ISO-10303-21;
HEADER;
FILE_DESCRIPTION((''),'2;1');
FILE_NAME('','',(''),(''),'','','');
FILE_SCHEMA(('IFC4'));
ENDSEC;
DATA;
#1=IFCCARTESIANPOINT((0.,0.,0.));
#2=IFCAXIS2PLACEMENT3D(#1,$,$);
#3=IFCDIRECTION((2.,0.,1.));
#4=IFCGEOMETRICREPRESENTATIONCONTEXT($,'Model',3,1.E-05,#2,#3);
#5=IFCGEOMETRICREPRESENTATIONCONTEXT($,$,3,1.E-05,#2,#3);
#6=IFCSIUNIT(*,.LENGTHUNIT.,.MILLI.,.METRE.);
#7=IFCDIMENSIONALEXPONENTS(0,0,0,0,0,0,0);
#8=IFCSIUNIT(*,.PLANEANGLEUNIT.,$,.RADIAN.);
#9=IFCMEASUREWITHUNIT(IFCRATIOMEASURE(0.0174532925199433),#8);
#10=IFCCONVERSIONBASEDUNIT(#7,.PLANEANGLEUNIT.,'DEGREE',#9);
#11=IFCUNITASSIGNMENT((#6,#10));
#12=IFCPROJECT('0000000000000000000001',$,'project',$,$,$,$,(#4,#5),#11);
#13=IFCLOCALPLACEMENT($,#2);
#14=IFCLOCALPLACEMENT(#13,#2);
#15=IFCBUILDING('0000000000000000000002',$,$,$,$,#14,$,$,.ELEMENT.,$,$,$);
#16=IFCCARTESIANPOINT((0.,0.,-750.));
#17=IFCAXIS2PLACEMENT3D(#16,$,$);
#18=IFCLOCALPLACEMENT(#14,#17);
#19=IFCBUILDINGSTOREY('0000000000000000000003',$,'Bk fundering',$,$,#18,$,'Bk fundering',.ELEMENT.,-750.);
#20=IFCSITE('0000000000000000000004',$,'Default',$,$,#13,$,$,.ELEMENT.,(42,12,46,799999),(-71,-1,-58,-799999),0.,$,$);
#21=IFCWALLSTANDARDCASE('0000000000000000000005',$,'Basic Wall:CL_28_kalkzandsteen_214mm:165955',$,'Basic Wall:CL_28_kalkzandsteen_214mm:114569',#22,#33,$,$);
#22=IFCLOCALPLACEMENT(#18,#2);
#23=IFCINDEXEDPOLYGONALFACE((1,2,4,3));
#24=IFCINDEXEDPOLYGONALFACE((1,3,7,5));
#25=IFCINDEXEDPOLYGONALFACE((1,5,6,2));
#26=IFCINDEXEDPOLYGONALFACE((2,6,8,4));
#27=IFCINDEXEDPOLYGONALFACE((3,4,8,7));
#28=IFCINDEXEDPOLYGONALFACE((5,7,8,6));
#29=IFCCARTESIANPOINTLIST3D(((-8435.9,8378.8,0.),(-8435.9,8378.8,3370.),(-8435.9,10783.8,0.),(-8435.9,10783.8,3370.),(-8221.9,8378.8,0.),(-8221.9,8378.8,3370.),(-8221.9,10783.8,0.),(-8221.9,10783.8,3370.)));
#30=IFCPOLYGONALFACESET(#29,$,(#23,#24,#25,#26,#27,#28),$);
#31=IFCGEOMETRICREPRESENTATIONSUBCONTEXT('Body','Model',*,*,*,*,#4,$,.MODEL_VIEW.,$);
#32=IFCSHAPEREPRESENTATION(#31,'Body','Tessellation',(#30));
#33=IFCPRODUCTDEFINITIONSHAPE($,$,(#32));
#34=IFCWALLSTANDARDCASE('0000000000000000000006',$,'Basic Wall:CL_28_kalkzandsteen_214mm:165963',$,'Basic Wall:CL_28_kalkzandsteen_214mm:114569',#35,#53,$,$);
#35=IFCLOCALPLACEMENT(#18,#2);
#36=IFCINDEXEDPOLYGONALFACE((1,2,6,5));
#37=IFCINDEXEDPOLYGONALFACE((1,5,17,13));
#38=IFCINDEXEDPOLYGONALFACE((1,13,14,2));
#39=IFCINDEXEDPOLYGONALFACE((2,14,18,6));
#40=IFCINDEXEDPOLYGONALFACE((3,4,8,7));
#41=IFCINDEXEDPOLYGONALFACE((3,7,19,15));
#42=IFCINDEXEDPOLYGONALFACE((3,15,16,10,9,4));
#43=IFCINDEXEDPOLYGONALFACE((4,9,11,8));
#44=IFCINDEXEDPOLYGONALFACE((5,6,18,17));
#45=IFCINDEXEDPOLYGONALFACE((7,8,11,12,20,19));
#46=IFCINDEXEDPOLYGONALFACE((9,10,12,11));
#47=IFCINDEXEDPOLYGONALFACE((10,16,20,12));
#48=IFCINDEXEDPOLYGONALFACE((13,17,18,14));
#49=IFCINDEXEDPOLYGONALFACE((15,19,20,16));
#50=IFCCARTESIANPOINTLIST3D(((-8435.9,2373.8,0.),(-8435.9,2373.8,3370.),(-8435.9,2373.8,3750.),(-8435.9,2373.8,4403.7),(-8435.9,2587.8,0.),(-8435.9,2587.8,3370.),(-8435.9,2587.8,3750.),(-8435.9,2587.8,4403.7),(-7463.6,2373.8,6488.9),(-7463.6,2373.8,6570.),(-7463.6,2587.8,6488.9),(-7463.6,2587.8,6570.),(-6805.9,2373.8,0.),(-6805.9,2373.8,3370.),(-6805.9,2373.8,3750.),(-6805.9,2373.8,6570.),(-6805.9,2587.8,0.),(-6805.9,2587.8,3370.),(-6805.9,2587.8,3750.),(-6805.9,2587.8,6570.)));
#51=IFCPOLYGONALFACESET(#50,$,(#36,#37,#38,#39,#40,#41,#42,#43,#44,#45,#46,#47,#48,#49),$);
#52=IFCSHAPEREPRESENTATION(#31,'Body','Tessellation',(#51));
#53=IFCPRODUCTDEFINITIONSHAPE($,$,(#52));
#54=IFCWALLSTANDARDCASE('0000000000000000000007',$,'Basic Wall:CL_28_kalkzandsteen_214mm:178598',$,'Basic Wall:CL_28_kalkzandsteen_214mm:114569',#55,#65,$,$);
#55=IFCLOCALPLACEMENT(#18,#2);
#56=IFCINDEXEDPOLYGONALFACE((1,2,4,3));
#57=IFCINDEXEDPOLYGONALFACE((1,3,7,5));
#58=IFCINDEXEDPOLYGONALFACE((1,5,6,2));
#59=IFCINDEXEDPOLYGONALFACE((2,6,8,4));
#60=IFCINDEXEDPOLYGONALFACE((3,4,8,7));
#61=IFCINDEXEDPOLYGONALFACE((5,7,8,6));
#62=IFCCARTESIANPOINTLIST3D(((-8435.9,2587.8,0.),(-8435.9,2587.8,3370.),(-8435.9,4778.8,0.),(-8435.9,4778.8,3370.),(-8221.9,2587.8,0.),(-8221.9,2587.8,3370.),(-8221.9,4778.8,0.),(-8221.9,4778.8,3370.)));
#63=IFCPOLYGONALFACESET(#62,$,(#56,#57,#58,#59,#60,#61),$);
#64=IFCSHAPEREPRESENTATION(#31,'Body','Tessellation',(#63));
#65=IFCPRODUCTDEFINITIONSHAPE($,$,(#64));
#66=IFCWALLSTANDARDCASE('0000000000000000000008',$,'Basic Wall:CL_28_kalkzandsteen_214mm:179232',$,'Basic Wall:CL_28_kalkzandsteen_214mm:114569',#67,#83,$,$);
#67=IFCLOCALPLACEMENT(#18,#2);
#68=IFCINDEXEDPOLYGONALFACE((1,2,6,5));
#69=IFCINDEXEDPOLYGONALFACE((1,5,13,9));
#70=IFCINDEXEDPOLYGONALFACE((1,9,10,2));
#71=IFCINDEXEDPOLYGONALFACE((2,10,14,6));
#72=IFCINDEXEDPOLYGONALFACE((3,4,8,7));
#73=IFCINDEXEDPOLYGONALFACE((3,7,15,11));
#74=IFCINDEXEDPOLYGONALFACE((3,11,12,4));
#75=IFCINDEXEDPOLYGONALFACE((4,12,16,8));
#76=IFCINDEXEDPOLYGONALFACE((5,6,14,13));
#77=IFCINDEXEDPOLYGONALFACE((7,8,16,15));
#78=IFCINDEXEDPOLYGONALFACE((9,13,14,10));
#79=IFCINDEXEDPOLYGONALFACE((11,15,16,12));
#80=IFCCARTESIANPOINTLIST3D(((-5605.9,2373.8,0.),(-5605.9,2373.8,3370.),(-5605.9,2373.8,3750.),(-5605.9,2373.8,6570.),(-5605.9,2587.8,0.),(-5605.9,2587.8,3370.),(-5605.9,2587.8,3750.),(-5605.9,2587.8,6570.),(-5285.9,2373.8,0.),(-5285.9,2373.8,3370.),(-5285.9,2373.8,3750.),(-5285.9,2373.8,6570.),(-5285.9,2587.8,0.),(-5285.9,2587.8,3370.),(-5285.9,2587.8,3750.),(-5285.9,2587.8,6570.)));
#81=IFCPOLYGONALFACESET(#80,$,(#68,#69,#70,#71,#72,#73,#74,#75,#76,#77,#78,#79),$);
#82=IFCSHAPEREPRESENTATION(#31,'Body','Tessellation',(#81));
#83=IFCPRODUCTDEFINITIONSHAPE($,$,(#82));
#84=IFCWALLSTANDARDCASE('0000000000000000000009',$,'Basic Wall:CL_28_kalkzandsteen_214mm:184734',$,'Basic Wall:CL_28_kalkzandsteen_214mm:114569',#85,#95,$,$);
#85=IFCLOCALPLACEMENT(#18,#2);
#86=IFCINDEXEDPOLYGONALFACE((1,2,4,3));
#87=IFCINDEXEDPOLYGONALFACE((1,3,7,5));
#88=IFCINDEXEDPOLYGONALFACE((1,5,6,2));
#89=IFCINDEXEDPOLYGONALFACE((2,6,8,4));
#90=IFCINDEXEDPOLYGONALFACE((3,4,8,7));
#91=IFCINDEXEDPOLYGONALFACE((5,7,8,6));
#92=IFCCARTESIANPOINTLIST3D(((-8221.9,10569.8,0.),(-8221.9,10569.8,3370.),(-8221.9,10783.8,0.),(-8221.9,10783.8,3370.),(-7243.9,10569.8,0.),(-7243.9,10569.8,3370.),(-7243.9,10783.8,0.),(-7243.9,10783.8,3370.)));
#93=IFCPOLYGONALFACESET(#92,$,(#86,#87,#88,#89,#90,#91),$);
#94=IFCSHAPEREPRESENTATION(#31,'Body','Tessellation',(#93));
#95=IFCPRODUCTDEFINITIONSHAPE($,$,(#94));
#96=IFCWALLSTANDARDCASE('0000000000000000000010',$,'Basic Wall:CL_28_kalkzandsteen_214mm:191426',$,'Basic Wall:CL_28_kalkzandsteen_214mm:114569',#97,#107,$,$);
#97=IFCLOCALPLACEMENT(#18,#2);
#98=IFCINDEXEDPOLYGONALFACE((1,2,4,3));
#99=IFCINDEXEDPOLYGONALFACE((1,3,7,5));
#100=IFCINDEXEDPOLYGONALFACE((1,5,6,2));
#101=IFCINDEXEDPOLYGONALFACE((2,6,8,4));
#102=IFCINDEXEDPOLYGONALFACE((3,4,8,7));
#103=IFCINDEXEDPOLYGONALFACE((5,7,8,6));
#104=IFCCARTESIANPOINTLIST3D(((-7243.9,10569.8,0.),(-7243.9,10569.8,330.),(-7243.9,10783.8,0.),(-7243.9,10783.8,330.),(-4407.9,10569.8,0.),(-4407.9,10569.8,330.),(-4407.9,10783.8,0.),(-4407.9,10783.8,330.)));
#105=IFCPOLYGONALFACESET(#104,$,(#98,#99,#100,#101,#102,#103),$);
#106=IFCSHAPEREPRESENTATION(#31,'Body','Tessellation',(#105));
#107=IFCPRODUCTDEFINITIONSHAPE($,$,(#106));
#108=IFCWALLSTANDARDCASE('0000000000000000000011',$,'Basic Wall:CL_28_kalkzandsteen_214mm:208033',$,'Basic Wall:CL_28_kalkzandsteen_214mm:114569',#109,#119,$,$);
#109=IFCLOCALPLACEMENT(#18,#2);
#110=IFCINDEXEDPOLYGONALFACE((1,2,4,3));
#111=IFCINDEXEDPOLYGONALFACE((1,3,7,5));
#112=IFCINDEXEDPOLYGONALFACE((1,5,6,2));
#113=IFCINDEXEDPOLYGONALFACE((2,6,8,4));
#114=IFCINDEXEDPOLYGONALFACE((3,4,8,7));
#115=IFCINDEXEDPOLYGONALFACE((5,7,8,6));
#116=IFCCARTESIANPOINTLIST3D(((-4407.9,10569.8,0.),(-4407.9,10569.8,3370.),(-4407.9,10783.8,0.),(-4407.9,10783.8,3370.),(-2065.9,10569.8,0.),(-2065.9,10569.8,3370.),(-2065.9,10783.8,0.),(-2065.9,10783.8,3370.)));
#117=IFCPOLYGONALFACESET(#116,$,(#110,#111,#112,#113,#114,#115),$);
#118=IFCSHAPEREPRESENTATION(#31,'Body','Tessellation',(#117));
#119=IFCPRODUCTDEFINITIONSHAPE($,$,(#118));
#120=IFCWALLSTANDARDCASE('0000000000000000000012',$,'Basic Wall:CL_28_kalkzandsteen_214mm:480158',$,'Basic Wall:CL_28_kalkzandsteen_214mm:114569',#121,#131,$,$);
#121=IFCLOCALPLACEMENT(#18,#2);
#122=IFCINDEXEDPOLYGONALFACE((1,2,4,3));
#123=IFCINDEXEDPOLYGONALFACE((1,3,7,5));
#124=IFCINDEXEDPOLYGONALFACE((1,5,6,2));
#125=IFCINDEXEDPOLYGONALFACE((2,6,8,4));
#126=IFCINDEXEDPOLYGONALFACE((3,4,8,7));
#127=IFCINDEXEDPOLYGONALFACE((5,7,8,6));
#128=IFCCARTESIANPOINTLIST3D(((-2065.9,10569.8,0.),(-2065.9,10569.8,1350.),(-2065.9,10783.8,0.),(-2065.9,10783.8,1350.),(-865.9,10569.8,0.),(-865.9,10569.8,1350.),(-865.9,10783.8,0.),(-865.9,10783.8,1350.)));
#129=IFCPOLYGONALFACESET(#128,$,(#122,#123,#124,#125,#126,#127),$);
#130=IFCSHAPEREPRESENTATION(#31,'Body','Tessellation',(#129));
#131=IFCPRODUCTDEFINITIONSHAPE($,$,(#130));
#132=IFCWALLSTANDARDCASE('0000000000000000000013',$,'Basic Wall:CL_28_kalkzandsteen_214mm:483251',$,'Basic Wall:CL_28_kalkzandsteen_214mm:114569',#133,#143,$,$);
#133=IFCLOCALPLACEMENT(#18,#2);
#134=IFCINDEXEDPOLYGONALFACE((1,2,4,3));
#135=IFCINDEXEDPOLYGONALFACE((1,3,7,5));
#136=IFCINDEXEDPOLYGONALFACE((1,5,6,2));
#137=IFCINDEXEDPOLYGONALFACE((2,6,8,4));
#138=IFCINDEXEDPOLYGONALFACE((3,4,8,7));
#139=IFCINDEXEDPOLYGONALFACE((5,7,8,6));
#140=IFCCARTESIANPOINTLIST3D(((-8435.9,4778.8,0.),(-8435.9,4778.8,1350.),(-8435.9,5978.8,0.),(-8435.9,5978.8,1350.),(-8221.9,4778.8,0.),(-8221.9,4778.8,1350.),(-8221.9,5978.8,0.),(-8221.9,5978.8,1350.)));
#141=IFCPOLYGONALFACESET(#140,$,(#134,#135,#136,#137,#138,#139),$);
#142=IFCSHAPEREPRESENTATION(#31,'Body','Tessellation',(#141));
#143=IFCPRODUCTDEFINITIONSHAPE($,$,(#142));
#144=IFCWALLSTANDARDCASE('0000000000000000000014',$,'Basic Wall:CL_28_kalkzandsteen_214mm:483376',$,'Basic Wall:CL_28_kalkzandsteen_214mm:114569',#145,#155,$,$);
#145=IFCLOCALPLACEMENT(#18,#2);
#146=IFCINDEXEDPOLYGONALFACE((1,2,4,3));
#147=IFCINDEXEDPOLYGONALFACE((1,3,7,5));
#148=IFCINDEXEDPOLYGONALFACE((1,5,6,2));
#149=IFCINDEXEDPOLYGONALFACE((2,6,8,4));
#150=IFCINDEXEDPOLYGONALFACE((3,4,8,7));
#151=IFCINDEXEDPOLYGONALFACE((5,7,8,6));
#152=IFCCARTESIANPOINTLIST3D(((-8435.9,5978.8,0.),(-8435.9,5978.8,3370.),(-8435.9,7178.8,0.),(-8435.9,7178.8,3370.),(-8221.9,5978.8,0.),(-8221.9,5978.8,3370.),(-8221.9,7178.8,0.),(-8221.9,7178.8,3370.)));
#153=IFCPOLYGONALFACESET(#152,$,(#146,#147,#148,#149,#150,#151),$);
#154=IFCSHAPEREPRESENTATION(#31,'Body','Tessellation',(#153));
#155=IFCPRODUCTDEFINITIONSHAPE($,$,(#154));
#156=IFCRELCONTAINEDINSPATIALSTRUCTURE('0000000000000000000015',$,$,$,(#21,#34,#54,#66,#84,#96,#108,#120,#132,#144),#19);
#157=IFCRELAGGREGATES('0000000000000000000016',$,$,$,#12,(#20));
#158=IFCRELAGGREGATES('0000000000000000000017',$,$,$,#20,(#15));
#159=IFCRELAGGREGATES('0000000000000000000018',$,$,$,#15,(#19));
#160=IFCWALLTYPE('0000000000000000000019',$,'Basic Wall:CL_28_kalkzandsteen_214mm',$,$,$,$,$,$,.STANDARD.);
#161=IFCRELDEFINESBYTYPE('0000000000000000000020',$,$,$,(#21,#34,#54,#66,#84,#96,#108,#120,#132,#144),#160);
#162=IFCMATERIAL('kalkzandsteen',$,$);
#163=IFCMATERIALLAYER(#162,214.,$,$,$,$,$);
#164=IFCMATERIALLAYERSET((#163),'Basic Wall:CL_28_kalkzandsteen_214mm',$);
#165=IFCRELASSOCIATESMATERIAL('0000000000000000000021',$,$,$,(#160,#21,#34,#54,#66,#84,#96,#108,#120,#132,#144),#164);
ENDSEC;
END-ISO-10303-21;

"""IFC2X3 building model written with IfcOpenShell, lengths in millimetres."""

from ifc_helpers import new_model, entity, si_unit, converted_unit, direction, frame, frame_2d, origin, place, context, subcontext, project, spatial, polyline, rectangle, extrude, clip, bounded_halfspace, material, layer, layer_set, layer_usage, type_object, element, save


model = new_model("IFC2X3")

# Units and contexts
model_context = context("Model", 3, precision=1e-05, world=origin(), true_north=direction((2.0, 0.0, 1.0)))
context_of_model = context(None, 3, precision=1e-05, world=origin(), true_north=direction((2.0, 0.0, 1.0)))
body_context = subcontext(model_context, "Body", "Model", "MODEL_VIEW")
ifc_project = project(units=[si_unit("LENGTHUNIT", "METRE", prefix="MILLI"), converted_unit("PLANEANGLEUNIT", "DEGREE", entity("IfcRatioMeasure", 0.0174532925199433), si_unit("PLANEANGLEUNIT", "RADIAN"), dimensions=[0, 0, 0, 0, 0, 0, 0])], contexts=[model_context, context_of_model])

# Site, building, storey
site_placement = place(None, origin())
site = spatial("IfcSite", under=ifc_project, at=site_placement, Name="Default", CompositionType="ELEMENT", RefLatitude=(42, 12, 46, 799999), RefLongitude=(-71, -1, -58, -799999), RefElevation=0.0)
building_placement = place(site_placement, origin())
building = spatial("IfcBuilding", under=site, at=building_placement, CompositionType="ELEMENT")
storey_placement = place(building_placement, frame((0.0, 0.0, -750.0)))
storey = spatial("IfcBuildingStorey", under=building, at=storey_placement, Name="Bk fundering", LongName="Bk fundering", CompositionType="ELEMENT", Elevation=-750.0)

# Wall
ifc_material_1 = material(Name="kalkzandsteen")
ifc_layer_1 = layer(ifc_material_1, 214.0)
ifc_layer_set_1 = layer_set([ifc_layer_1], Name="Basic Wall:CL_28_kalkzandsteen_214mm")
ifc_layer_usage_1 = layer_usage(ifc_layer_set_1, "AXIS2", "NEGATIVE", 107.0)
wall_type_1 = type_object("IfcWallType", Name="Basic Wall:CL_28_kalkzandsteen_214mm", PredefinedType="STANDARD", material=ifc_layer_set_1)
wall_1_placement = place(storey_placement, frame((-8328.9, 10783.8, 0.0), z_axis=(0.0, 0.0, 1.0), x_axis=(0.0, -1.0, 0.0)))
element("IfcWallStandardCase", 1, at=wall_1_placement, inside=storey, type_object=wall_type_1, material=ifc_layer_usage_1, Name="Basic Wall:CL_28_kalkzandsteen_214mm:165955", ObjectType="Basic Wall:CL_28_kalkzandsteen_214mm:114569", context=body_context, shape_type="Clipping", body=[
    clip(extrude(rectangle(XDim=2405.0, YDim=214.0, at=frame_2d((1202.5, 0.0), x_axis=(-1.0, 0.0))), origin(), (0.0, 0.0, 1.0), 3370.0), bounded_halfspace(frame((0.0, -107.0, 3370.0), z_axis=(0.0, 0.0, -1.0), x_axis=(0.0, 1.0, 0.0)), True, frame((0.0, -107.0, 3370.0)), polyline([(0.0, 0.0), (2405.0, 0.0), (2405.0, 214.0), (214.0, 214.0), (0.0, 214.0), (0.0, 0.0)]))),
])

# Wall, opening
ifc_layer_usage_2 = layer_usage(ifc_layer_set_1, "AXIS2", "NEGATIVE", 107.0)
wall_2_placement = place(storey_placement, frame((-8435.9, 2480.8, 0.0)))
wall_2 = element("IfcWallStandardCase", 2, at=wall_2_placement, inside=storey, type_object=wall_type_1, material=ifc_layer_usage_2, Name="Basic Wall:CL_28_kalkzandsteen_214mm:165963", ObjectType="Basic Wall:CL_28_kalkzandsteen_214mm:114569", context=body_context, shape_type="Clipping", body=[
    clip(extrude(rectangle(XDim=1630.0, YDim=214.0, at=frame_2d((815.0, 0.0), x_axis=(-1.0, 0.0))), origin(), (0.0, 0.0, 1.0), 6570.0), bounded_halfspace(frame((0.0, -107.0, 4403.7), z_axis=(-0.906308, 0.0, 0.422618), x_axis=(0.0, -1.0, 0.0)), False, frame((0.0, -107.0, 4403.7)), polyline([(0.0, 0.0), (972.3, 0.0), (972.3, 214.0), (0.0, 214.0), (0.0, 0.0)]))),
])
opening_1_placement = place(storey_placement, frame((-8435.9, 2480.8, 0.0)))
element("IfcOpeningElement", 3, at=opening_1_placement, cuts=wall_2, ObjectType="Opening", context=body_context, shape_type="SweptSolid", body=[
    extrude(rectangle(XDim=1630.0, YDim=214.0, at=frame_2d((120.2, -21.4), x_axis=(1.0, 0.0))), frame((694.8, 21.4, 3370.0)), (0.0, 0.0, 1.0), 380.0),
])

# Wall
ifc_layer_usage_3 = layer_usage(ifc_layer_set_1, "AXIS2", "NEGATIVE", 107.0)
wall_3_placement = place(storey_placement, frame((-8328.9, 4778.8, 0.0), z_axis=(0.0, 0.0, 1.0), x_axis=(0.0, -1.0, 0.0)))
element("IfcWallStandardCase", 4, at=wall_3_placement, inside=storey, type_object=wall_type_1, material=ifc_layer_usage_3, Name="Basic Wall:CL_28_kalkzandsteen_214mm:178598", ObjectType="Basic Wall:CL_28_kalkzandsteen_214mm:114569", context=body_context, shape_type="Clipping", body=[
    clip(extrude(rectangle(XDim=2191.0, YDim=214.0, at=frame_2d((1095.5, 0.0), x_axis=(-1.0, 0.0))), origin(), (0.0, 0.0, 1.0), 3370.0), bounded_halfspace(frame((0.0, -107.0, 3370.0), z_axis=(0.0, 0.0, -1.0), x_axis=(0.0, 1.0, 0.0)), True, frame((0.0, -107.0, 3370.0)), polyline([(0.0, 0.0), (2191.0, 0.0), (2191.0, 214.0), (0.0, 214.0), (0.0, 0.0)]))),
])

# Wall, opening
ifc_layer_usage_4 = layer_usage(ifc_layer_set_1, "AXIS2", "NEGATIVE", 107.0)
wall_4_placement = place(storey_placement, frame((-5605.9, 2480.8, 0.0)))
wall_4 = element("IfcWallStandardCase", 5, at=wall_4_placement, inside=storey, type_object=wall_type_1, material=ifc_layer_usage_4, Name="Basic Wall:CL_28_kalkzandsteen_214mm:179232", ObjectType="Basic Wall:CL_28_kalkzandsteen_214mm:114569", context=body_context, shape_type="SweptSolid", body=[
    extrude(rectangle(XDim=320.0, YDim=214.0, at=frame_2d((160.0, 0.0), x_axis=(-1.0, 0.0))), origin(), (0.0, 0.0, 1.0), 6570.0),
])
opening_2_placement = place(storey_placement, frame((-5605.9, 2480.8, 0.0)))
element("IfcOpeningElement", 6, at=opening_2_placement, cuts=wall_4, ObjectType="Opening", context=body_context, shape_type="SweptSolid", body=[
    extrude(rectangle(XDim=320.0, YDim=214.0, at=frame_2d((0.0, 0.0), x_axis=(1.0, 0.0))), frame((160.0, 0.0, 3370.0)), (0.0, 0.0, 1.0), 380.0),
])

# Walls
ifc_layer_usage_5 = layer_usage(ifc_layer_set_1, "AXIS2", "NEGATIVE", 107.0)
wall_5_placement = place(storey_placement, frame((-7243.9, 10676.8, 0.0), z_axis=(0.0, 0.0, 1.0), x_axis=(-1.0, 0.0, 0.0)))
element("IfcWallStandardCase", 7, at=wall_5_placement, inside=storey, type_object=wall_type_1, material=ifc_layer_usage_5, Name="Basic Wall:CL_28_kalkzandsteen_214mm:184734", ObjectType="Basic Wall:CL_28_kalkzandsteen_214mm:114569", context=body_context, shape_type="Clipping", body=[
    clip(extrude(rectangle(XDim=978.0, YDim=214.0, at=frame_2d((489.0, 0.0), x_axis=(-1.0, 0.0))), origin(), (0.0, 0.0, 1.0), 3370.0), bounded_halfspace(frame((0.0, -107.0, 3370.0), z_axis=(0.0, 0.0, -1.0), x_axis=(-1.0, 0.0, 0.0)), True, frame((0.0, -107.0, 3370.0)), polyline([(0.0, 0.0), (978.0, 0.0), (978.0, 214.0), (0.0, 214.0), (0.0, 0.0)]))),
])
ifc_layer_usage_6 = layer_usage(ifc_layer_set_1, "AXIS2", "NEGATIVE", 107.0)
wall_6_placement = place(storey_placement, frame((-4407.9, 10676.8, 0.0), z_axis=(0.0, 0.0, 1.0), x_axis=(-1.0, 0.0, 0.0)))
element("IfcWallStandardCase", 8, at=wall_6_placement, inside=storey, type_object=wall_type_1, material=ifc_layer_usage_6, Name="Basic Wall:CL_28_kalkzandsteen_214mm:191426", ObjectType="Basic Wall:CL_28_kalkzandsteen_214mm:114569", context=body_context, shape_type="SweptSolid", body=[
    extrude(rectangle(XDim=2836.0, YDim=214.0, at=frame_2d((1418.0, 0.0), x_axis=(-1.0, 0.0))), origin(), (0.0, 0.0, 1.0), 330.0),
])
ifc_layer_usage_7 = layer_usage(ifc_layer_set_1, "AXIS2", "NEGATIVE", 107.0)
wall_7_placement = place(storey_placement, frame((-2065.9, 10676.8, 0.0), z_axis=(0.0, 0.0, 1.0), x_axis=(-1.0, 0.0, 0.0)))
element("IfcWallStandardCase", 9, at=wall_7_placement, inside=storey, type_object=wall_type_1, material=ifc_layer_usage_7, Name="Basic Wall:CL_28_kalkzandsteen_214mm:208033", ObjectType="Basic Wall:CL_28_kalkzandsteen_214mm:114569", context=body_context, shape_type="Clipping", body=[
    clip(extrude(rectangle(XDim=2342.0, YDim=214.0, at=frame_2d((1171.0, 0.0), x_axis=(-1.0, 0.0))), origin(), (0.0, 0.0, 1.0), 3370.0), bounded_halfspace(frame((0.0, -107.0, 3370.0), z_axis=(0.0, 0.0, -1.0), x_axis=(-1.0, 0.0, 0.0)), True, frame((0.0, -107.0, 3370.0)), polyline([(0.0, 0.0), (2342.0, 0.0), (2342.0, 214.0), (0.0, 214.0), (0.0, 0.0)]))),
])
ifc_layer_usage_8 = layer_usage(ifc_layer_set_1, "AXIS2", "NEGATIVE", 107.0)
wall_8_placement = place(storey_placement, frame((-865.9, 10676.8, 0.0), z_axis=(0.0, 0.0, 1.0), x_axis=(-1.0, 0.0, 0.0)))
element("IfcWallStandardCase", 10, at=wall_8_placement, inside=storey, type_object=wall_type_1, material=ifc_layer_usage_8, Name="Basic Wall:CL_28_kalkzandsteen_214mm:480158", ObjectType="Basic Wall:CL_28_kalkzandsteen_214mm:114569", context=body_context, shape_type="SweptSolid", body=[
    extrude(rectangle(XDim=1200.0, YDim=214.0, at=frame_2d((600.0, 0.0), x_axis=(-1.0, 0.0))), origin(), (0.0, 0.0, 1.0), 1350.0),
])
ifc_layer_usage_9 = layer_usage(ifc_layer_set_1, "AXIS2", "NEGATIVE", 107.0)
wall_9_placement = place(storey_placement, frame((-8328.9, 5978.8, 0.0), z_axis=(0.0, 0.0, 1.0), x_axis=(0.0, -1.0, 0.0)))
element("IfcWallStandardCase", 11, at=wall_9_placement, inside=storey, type_object=wall_type_1, material=ifc_layer_usage_9, Name="Basic Wall:CL_28_kalkzandsteen_214mm:483251", ObjectType="Basic Wall:CL_28_kalkzandsteen_214mm:114569", context=body_context, shape_type="SweptSolid", body=[
    extrude(rectangle(XDim=1200.0, YDim=214.0, at=frame_2d((600.0, 0.0), x_axis=(-1.0, 0.0))), origin(), (0.0, 0.0, 1.0), 1350.0),
])
ifc_layer_usage_10 = layer_usage(ifc_layer_set_1, "AXIS2", "NEGATIVE", 107.0)
wall_10_placement = place(storey_placement, frame((-8328.9, 7178.8, 0.0), z_axis=(0.0, 0.0, 1.0), x_axis=(0.0, -1.0, 0.0)))
element("IfcWallStandardCase", 12, at=wall_10_placement, inside=storey, type_object=wall_type_1, material=ifc_layer_usage_10, Name="Basic Wall:CL_28_kalkzandsteen_214mm:483376", ObjectType="Basic Wall:CL_28_kalkzandsteen_214mm:114569", context=body_context, shape_type="Clipping", body=[
    clip(extrude(rectangle(XDim=1200.0, YDim=214.0, at=frame_2d((600.0, 0.0), x_axis=(-1.0, 0.0))), origin(), (0.0, 0.0, 1.0), 3370.0), bounded_halfspace(frame((0.0, -107.0, 3370.0), z_axis=(0.0, 0.0, -1.0), x_axis=(0.0, 1.0, 0.0)), True, frame((0.0, -107.0, 3370.0)), polyline([(0.0, 0.0), (1200.0, 0.0), (1200.0, 214.0), (0.0, 214.0), (0.0, 0.0)]))),
])

save(model, "model.ifc")
